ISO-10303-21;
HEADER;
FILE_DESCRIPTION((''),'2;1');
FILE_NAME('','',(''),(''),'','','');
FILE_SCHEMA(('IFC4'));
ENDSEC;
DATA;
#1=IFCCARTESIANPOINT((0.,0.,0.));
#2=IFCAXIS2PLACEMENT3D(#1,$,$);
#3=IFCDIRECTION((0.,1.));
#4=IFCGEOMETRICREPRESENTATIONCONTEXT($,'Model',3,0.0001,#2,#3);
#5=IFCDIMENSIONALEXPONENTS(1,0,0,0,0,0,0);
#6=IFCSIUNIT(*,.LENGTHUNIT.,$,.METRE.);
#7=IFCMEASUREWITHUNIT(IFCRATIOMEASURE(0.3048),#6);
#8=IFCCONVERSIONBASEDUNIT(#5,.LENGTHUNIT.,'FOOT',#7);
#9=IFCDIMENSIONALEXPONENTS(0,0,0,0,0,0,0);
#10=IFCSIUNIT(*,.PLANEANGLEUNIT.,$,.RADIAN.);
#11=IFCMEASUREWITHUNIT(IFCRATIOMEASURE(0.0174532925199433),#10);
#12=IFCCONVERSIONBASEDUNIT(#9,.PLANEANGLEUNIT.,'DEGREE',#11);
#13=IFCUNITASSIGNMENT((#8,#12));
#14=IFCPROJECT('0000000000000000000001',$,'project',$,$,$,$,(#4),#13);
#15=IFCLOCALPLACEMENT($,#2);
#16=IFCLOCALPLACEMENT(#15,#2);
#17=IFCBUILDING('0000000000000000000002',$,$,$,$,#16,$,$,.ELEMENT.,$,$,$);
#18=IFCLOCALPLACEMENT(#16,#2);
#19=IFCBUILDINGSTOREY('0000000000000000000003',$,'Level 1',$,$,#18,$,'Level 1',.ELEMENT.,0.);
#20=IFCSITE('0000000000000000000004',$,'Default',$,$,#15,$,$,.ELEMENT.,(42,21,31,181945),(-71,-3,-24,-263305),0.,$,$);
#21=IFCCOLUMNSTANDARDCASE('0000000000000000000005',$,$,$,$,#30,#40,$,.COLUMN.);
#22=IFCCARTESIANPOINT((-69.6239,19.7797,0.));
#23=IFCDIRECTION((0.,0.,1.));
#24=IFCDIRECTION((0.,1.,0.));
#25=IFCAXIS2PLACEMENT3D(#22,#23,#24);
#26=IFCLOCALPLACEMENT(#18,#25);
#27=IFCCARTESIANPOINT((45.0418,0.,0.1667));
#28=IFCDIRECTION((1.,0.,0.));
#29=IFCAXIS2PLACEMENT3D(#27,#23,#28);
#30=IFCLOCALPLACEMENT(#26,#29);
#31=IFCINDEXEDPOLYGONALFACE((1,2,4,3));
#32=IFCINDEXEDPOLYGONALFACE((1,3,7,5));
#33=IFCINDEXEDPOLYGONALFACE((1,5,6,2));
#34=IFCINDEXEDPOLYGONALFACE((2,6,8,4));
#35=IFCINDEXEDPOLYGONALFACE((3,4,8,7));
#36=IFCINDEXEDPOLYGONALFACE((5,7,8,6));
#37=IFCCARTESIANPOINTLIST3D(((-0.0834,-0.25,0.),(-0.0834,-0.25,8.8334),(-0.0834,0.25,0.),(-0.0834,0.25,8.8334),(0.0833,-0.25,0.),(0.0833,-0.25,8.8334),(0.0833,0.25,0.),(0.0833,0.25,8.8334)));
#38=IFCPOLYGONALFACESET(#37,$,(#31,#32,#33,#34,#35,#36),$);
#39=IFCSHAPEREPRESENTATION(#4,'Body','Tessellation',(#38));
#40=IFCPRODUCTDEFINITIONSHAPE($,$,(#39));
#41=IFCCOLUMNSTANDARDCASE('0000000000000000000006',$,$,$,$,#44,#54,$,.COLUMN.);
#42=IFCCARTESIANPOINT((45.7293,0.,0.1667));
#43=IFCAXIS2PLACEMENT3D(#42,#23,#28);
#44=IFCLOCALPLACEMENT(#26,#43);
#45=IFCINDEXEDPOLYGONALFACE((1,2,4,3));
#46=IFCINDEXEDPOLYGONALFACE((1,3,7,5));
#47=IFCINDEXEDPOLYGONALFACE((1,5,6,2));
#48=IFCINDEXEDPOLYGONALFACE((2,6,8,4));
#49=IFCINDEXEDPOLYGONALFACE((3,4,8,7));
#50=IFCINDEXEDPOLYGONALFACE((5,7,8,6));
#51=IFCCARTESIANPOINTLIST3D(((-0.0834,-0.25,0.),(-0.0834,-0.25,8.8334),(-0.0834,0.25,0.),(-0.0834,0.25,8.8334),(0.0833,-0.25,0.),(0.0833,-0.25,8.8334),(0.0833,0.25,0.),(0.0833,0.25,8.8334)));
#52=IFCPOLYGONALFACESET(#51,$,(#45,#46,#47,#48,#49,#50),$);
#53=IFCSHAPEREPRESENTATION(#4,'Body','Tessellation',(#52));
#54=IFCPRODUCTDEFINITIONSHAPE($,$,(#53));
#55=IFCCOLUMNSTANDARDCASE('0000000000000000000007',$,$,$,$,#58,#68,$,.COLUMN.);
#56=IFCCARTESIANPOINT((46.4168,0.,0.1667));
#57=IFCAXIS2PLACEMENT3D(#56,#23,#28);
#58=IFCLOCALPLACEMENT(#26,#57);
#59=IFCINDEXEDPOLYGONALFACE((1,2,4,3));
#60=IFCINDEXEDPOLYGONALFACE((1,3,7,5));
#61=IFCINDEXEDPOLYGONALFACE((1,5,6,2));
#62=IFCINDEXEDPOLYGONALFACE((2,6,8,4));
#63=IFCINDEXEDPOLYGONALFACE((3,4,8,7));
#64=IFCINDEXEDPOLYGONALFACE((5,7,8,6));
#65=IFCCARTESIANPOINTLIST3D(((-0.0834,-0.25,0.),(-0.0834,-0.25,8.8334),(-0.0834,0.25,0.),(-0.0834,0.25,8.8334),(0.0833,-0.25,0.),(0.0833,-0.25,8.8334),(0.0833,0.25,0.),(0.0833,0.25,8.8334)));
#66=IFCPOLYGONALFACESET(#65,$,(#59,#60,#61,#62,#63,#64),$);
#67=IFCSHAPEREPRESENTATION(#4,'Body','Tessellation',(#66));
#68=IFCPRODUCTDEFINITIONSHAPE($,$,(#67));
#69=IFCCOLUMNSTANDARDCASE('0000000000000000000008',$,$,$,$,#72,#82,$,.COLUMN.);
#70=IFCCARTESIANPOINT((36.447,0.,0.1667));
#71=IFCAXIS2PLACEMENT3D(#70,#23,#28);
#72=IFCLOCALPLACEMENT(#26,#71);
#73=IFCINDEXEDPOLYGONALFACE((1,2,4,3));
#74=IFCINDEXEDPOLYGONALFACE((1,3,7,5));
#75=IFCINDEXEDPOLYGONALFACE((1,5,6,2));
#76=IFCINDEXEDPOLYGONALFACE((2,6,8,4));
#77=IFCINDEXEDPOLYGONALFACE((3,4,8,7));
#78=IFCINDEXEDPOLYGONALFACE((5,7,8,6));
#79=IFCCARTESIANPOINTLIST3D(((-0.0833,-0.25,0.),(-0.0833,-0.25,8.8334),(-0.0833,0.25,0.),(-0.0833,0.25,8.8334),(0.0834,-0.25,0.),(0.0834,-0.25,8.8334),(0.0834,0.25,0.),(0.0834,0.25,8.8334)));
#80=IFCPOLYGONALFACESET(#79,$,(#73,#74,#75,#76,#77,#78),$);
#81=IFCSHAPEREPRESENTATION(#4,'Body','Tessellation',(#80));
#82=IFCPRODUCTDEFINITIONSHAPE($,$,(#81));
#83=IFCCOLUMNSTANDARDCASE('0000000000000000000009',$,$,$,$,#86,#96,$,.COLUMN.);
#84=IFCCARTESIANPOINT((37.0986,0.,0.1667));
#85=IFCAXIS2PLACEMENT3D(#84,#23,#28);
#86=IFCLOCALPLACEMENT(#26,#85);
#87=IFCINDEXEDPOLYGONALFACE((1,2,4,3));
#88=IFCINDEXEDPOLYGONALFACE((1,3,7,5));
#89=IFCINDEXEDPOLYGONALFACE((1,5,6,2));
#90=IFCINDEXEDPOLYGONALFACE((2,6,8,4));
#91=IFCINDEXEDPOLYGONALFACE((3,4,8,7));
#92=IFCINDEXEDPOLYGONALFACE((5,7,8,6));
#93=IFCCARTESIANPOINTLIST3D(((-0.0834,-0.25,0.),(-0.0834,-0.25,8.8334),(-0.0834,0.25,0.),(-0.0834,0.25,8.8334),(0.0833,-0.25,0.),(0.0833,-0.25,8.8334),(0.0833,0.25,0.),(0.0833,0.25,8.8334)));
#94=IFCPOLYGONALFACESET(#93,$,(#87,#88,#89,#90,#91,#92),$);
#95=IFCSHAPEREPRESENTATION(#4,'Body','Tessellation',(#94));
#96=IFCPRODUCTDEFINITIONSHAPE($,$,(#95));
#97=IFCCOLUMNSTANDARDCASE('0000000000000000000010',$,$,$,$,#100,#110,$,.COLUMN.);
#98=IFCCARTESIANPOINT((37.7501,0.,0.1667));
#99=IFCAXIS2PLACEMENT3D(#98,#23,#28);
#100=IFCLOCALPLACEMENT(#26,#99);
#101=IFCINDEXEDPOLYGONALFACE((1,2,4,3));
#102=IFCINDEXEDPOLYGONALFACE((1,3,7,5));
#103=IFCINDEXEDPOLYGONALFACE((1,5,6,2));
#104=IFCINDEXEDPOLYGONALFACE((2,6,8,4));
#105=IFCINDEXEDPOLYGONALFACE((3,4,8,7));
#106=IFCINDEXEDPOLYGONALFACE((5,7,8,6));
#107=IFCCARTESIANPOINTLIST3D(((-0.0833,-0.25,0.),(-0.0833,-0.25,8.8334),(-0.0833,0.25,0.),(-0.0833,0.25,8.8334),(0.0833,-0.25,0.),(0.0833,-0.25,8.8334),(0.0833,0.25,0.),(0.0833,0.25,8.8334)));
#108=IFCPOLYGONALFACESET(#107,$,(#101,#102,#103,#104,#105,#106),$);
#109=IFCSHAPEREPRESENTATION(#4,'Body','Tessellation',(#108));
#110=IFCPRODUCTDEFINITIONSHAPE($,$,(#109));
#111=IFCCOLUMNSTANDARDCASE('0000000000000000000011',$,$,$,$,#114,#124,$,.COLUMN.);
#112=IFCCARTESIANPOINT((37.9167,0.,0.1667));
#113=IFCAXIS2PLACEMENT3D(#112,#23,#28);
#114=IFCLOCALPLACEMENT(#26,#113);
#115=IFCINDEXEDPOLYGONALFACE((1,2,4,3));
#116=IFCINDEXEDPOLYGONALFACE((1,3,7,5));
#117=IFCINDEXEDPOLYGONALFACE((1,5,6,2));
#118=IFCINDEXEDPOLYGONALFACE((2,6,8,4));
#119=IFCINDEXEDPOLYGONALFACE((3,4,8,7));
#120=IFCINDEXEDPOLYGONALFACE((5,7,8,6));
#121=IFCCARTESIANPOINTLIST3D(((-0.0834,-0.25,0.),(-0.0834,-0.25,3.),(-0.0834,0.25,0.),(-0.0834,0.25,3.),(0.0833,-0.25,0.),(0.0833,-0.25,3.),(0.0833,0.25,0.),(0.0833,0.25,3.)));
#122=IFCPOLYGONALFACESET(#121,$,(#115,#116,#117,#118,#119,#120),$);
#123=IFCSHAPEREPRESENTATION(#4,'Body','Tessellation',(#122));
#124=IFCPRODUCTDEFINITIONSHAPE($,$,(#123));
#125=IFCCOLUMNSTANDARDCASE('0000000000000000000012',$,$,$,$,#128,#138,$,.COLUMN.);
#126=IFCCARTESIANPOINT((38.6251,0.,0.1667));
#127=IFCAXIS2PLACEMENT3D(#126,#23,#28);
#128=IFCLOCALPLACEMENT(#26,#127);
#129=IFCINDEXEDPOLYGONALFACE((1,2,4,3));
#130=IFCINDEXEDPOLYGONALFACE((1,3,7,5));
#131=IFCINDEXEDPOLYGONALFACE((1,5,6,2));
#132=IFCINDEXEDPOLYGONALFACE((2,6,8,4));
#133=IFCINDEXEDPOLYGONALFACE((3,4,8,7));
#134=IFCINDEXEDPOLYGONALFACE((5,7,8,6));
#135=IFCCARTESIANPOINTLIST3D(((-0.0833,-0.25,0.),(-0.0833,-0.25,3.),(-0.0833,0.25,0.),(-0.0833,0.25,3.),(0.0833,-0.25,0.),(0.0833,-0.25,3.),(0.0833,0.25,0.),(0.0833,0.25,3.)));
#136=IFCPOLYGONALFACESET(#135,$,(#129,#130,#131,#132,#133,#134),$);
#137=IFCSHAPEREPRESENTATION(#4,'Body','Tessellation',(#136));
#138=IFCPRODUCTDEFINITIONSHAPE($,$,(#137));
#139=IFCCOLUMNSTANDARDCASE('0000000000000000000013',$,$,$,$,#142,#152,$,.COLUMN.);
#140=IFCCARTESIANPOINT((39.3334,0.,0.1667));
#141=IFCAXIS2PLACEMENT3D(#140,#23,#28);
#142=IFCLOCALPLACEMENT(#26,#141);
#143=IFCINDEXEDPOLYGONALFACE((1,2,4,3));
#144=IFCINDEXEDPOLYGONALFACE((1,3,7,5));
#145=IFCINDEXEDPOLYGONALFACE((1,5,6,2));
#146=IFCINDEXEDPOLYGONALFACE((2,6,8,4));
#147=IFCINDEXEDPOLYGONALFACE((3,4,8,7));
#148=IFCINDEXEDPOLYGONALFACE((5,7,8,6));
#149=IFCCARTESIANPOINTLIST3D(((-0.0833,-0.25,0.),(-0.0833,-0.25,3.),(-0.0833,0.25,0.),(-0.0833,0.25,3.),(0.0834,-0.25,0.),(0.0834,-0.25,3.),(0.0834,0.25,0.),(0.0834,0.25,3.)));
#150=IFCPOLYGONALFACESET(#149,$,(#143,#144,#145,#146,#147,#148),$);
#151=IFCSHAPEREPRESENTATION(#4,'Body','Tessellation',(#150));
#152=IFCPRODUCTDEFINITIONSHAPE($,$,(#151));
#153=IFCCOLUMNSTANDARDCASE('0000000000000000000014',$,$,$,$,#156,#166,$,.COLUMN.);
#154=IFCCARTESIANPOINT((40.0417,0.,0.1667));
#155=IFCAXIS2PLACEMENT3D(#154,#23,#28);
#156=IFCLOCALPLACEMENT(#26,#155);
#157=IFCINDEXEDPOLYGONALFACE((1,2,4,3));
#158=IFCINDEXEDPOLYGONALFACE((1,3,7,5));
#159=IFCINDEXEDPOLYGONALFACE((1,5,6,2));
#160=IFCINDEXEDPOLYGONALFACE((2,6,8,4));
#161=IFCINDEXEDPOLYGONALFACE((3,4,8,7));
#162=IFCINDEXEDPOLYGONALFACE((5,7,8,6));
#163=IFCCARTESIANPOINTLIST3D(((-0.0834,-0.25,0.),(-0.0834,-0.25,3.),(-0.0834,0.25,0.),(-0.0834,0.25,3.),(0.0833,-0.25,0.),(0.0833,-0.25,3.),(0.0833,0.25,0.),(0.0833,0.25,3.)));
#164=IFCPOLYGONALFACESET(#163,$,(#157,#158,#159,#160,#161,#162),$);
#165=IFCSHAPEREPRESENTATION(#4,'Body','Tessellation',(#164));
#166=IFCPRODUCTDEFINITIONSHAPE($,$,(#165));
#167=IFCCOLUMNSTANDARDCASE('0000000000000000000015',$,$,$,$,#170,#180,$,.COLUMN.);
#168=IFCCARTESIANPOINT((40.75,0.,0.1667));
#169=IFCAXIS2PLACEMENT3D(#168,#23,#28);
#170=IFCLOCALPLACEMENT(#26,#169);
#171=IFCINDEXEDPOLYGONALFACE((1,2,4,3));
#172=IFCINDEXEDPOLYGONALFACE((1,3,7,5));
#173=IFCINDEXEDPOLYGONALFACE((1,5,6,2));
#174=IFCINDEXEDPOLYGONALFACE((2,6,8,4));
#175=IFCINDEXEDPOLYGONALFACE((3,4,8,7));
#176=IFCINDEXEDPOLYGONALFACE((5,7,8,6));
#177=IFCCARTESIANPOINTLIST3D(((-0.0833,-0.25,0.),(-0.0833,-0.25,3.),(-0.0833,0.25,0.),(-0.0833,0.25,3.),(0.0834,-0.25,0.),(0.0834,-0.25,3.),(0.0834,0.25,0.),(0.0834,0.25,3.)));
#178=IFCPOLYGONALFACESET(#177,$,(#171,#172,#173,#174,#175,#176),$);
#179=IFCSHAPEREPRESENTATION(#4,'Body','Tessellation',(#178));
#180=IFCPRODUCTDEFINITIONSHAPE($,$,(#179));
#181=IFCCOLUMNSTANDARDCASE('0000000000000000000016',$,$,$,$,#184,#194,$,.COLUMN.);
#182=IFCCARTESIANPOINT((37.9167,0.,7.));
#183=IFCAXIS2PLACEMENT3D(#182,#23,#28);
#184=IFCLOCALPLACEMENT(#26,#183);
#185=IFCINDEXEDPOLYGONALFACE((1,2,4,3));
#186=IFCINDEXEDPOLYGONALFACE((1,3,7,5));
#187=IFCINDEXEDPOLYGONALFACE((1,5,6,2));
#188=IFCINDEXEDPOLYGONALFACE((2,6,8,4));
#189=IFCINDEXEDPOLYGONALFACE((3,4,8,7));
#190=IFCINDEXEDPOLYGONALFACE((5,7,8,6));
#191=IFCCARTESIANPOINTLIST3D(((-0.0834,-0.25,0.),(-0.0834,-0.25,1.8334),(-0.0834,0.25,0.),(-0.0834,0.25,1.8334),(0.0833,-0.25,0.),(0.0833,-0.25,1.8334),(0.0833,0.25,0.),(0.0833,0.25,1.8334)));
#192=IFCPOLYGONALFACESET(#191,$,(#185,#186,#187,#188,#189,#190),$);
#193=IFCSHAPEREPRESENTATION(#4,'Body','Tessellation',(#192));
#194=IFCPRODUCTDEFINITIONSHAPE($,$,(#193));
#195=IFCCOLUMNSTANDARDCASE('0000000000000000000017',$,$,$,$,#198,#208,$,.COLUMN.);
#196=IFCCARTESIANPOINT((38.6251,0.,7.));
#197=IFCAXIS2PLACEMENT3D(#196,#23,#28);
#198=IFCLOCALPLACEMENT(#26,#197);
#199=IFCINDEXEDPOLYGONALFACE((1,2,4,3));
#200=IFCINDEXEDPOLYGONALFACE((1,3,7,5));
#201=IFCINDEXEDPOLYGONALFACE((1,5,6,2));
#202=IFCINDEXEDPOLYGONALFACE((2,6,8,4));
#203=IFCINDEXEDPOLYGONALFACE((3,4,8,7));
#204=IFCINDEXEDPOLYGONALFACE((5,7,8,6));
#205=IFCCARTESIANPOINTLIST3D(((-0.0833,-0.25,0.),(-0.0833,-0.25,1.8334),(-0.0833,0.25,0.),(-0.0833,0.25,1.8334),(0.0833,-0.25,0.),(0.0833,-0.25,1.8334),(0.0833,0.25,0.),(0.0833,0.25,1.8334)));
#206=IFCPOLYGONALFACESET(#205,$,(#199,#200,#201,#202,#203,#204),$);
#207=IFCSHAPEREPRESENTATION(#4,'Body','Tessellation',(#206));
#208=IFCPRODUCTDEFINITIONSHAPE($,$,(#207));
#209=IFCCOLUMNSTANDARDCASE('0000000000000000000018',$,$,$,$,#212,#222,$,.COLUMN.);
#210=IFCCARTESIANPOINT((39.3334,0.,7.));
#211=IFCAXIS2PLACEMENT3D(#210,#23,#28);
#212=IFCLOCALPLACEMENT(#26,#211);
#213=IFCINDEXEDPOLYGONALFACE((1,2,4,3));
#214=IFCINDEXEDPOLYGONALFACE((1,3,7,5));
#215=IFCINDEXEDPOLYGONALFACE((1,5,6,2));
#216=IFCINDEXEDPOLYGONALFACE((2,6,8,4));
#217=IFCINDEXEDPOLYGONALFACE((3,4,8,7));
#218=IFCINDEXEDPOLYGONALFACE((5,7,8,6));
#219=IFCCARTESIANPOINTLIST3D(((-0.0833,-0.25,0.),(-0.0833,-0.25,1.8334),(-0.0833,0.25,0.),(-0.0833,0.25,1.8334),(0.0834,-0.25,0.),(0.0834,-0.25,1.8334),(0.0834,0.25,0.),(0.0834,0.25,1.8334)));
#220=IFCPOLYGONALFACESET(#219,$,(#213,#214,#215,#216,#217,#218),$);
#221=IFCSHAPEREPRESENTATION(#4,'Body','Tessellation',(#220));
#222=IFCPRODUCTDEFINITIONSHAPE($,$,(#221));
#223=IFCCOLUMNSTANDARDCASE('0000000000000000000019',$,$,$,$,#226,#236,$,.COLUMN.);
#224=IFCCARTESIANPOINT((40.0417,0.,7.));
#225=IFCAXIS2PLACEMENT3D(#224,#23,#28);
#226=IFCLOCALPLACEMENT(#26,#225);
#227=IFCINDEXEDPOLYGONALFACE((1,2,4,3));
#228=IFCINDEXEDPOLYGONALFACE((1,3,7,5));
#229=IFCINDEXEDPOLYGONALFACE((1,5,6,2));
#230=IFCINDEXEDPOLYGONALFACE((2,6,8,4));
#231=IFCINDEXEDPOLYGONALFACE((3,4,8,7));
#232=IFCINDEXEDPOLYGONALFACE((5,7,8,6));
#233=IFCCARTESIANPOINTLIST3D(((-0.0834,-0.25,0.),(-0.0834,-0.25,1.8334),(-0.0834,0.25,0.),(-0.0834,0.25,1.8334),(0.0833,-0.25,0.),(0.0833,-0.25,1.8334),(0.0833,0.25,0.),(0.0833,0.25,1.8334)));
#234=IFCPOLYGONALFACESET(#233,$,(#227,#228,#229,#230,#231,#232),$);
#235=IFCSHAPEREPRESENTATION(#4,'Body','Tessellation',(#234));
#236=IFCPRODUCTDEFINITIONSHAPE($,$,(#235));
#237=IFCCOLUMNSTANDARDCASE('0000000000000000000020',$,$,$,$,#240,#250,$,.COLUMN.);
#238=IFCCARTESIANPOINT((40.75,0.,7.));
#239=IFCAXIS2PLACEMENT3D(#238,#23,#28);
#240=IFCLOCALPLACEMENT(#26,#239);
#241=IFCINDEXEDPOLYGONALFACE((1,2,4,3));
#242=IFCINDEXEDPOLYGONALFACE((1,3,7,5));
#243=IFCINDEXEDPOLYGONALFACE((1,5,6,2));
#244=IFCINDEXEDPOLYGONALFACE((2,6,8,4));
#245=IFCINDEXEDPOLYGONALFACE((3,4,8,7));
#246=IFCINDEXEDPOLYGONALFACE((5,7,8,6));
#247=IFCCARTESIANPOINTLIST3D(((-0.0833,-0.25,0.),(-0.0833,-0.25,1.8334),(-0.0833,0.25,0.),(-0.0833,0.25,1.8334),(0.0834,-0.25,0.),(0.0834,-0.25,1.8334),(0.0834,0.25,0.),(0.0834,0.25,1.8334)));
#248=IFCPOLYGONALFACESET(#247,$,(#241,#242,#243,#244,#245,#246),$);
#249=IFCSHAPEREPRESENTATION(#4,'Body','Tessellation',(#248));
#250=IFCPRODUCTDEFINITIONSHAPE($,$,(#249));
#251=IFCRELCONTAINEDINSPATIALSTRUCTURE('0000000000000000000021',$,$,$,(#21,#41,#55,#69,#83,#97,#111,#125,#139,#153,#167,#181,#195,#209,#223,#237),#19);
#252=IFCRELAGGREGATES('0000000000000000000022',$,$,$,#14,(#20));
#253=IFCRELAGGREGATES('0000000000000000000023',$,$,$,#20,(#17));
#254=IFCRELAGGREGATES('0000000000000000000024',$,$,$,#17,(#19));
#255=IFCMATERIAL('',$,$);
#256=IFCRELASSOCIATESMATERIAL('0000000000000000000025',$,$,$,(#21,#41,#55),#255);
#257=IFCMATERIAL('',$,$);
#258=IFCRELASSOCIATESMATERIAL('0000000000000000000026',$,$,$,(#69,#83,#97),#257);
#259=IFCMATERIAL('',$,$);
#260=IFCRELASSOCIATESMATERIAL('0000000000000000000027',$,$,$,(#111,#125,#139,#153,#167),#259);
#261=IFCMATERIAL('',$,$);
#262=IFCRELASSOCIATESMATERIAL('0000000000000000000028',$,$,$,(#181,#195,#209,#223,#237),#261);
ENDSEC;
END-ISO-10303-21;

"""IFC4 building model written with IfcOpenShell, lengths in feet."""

from ifc_helpers import new_model, entity, si_unit, converted_unit, direction, frame, origin, place, context, project, spatial, rectangle, extrude, material, element, save


model = new_model("IFC4")

# Units and contexts
model_context = context("Model", 3, precision=0.0001, world=origin(), true_north=direction((0.0, 1.0)))
ifc_project = project(units=[converted_unit("LENGTHUNIT", "FOOT", entity("IfcRatioMeasure", 0.3048), si_unit("LENGTHUNIT", "METRE"), dimensions=[1, 0, 0, 0, 0, 0, 0]), converted_unit("PLANEANGLEUNIT", "DEGREE", entity("IfcRatioMeasure", 0.0174532925199433), si_unit("PLANEANGLEUNIT", "RADIAN"), dimensions=[0, 0, 0, 0, 0, 0, 0])], contexts=[model_context])

# Site, building, storey
site_placement = place(None, origin())
site = spatial("IfcSite", under=ifc_project, at=site_placement, Name="Default", CompositionType="ELEMENT", RefLatitude=(42, 21, 31, 181945), RefLongitude=(-71, -3, -24, -263305), RefElevation=0.0)
building_placement = place(site_placement, origin())
building = spatial("IfcBuilding", under=site, at=building_placement, CompositionType="ELEMENT")
storey_placement = place(building_placement, origin())
storey = spatial("IfcBuildingStorey", under=building, at=storey_placement, Name="Level 1", LongName="Level 1", CompositionType="ELEMENT", Elevation=0.0)

# Columns
ifc_material_1 = material(Name="")
placement_1 = place(storey_placement, frame((-69.6239, 19.7797, 0.0), z_axis=(0.0, 0.0, 1.0), x_axis=(0.0, 1.0, 0.0)))
for number, where, z_axis, x_axis in (
    (1, (45.0418, 0.0, 0.1667), (0.0, 0.0, 1.0), (1.0, 0.0, 0.0)),
    (2, (45.7293, 0.0, 0.1667), (0.0, 0.0, 1.0), (1.0, 0.0, 0.0)),
    (3, (46.4168, 0.0, 0.1667), (0.0, 0.0, 1.0), (1.0, 0.0, 0.0)),
):
    element("IfcColumnStandardCase", number, at=place(placement_1, frame(where, z_axis=z_axis, x_axis=x_axis)), inside=storey, material=ifc_material_1, PredefinedType="COLUMN", context=model_context, shape_type="SweptSolid", body=[
        extrude(rectangle(XDim=0.1667, YDim=0.5), origin(), (0.0, 0.0, 1.0), 8.8334),
    ])
ifc_material_2 = material(Name="")
for number, where, z_axis, x_axis in (
    (4, (36.447, 0.0, 0.1667), (0.0, 0.0, 1.0), (1.0, 0.0, 0.0)),
    (5, (37.0986, 0.0, 0.1667), (0.0, 0.0, 1.0), (1.0, 0.0, 0.0)),
    (6, (37.7501, 0.0, 0.1667), (0.0, 0.0, 1.0), (1.0, 0.0, 0.0)),
):
    element("IfcColumnStandardCase", number, at=place(placement_1, frame(where, z_axis=z_axis, x_axis=x_axis)), inside=storey, material=ifc_material_2, PredefinedType="COLUMN", context=model_context, shape_type="SweptSolid", body=[
        extrude(rectangle(XDim=0.1667, YDim=0.5), origin(), (0.0, 0.0, 1.0), 8.8334),
    ])
ifc_material_3 = material(Name="")
for number, where, z_axis, x_axis in (
    (7, (37.9167, 0.0, 0.1667), (0.0, 0.0, 1.0), (1.0, 0.0, 0.0)),
    (8, (38.6251, 0.0, 0.1667), (0.0, 0.0, 1.0), (1.0, 0.0, 0.0)),
    (9, (39.3334, 0.0, 0.1667), (0.0, 0.0, 1.0), (1.0, 0.0, 0.0)),
    (10, (40.0417, 0.0, 0.1667), (0.0, 0.0, 1.0), (1.0, 0.0, 0.0)),
    (11, (40.75, 0.0, 0.1667), (0.0, 0.0, 1.0), (1.0, 0.0, 0.0)),
):
    element("IfcColumnStandardCase", number, at=place(placement_1, frame(where, z_axis=z_axis, x_axis=x_axis)), inside=storey, material=ifc_material_3, PredefinedType="COLUMN", context=model_context, shape_type="SweptSolid", body=[
        extrude(rectangle(XDim=0.1667, YDim=0.5), origin(), (0.0, 0.0, 1.0), 3.0),
    ])
ifc_material_4 = material(Name="")
for number, where, z_axis, x_axis in (
    (12, (37.9167, 0.0, 7.0), (0.0, 0.0, 1.0), (1.0, 0.0, 0.0)),
    (13, (38.6251, 0.0, 7.0), (0.0, 0.0, 1.0), (1.0, 0.0, 0.0)),
    (14, (39.3334, 0.0, 7.0), (0.0, 0.0, 1.0), (1.0, 0.0, 0.0)),
    (15, (40.0417, 0.0, 7.0), (0.0, 0.0, 1.0), (1.0, 0.0, 0.0)),
    (16, (40.75, 0.0, 7.0), (0.0, 0.0, 1.0), (1.0, 0.0, 0.0)),
):
    element("IfcColumnStandardCase", number, at=place(placement_1, frame(where, z_axis=z_axis, x_axis=x_axis)), inside=storey, material=ifc_material_4, PredefinedType="COLUMN", context=model_context, shape_type="SweptSolid", body=[
        extrude(rectangle(XDim=0.1667, YDim=0.5), origin(), (0.0, 0.0, 1.0), 1.8334),
    ])

save(model, "model.ifc")
